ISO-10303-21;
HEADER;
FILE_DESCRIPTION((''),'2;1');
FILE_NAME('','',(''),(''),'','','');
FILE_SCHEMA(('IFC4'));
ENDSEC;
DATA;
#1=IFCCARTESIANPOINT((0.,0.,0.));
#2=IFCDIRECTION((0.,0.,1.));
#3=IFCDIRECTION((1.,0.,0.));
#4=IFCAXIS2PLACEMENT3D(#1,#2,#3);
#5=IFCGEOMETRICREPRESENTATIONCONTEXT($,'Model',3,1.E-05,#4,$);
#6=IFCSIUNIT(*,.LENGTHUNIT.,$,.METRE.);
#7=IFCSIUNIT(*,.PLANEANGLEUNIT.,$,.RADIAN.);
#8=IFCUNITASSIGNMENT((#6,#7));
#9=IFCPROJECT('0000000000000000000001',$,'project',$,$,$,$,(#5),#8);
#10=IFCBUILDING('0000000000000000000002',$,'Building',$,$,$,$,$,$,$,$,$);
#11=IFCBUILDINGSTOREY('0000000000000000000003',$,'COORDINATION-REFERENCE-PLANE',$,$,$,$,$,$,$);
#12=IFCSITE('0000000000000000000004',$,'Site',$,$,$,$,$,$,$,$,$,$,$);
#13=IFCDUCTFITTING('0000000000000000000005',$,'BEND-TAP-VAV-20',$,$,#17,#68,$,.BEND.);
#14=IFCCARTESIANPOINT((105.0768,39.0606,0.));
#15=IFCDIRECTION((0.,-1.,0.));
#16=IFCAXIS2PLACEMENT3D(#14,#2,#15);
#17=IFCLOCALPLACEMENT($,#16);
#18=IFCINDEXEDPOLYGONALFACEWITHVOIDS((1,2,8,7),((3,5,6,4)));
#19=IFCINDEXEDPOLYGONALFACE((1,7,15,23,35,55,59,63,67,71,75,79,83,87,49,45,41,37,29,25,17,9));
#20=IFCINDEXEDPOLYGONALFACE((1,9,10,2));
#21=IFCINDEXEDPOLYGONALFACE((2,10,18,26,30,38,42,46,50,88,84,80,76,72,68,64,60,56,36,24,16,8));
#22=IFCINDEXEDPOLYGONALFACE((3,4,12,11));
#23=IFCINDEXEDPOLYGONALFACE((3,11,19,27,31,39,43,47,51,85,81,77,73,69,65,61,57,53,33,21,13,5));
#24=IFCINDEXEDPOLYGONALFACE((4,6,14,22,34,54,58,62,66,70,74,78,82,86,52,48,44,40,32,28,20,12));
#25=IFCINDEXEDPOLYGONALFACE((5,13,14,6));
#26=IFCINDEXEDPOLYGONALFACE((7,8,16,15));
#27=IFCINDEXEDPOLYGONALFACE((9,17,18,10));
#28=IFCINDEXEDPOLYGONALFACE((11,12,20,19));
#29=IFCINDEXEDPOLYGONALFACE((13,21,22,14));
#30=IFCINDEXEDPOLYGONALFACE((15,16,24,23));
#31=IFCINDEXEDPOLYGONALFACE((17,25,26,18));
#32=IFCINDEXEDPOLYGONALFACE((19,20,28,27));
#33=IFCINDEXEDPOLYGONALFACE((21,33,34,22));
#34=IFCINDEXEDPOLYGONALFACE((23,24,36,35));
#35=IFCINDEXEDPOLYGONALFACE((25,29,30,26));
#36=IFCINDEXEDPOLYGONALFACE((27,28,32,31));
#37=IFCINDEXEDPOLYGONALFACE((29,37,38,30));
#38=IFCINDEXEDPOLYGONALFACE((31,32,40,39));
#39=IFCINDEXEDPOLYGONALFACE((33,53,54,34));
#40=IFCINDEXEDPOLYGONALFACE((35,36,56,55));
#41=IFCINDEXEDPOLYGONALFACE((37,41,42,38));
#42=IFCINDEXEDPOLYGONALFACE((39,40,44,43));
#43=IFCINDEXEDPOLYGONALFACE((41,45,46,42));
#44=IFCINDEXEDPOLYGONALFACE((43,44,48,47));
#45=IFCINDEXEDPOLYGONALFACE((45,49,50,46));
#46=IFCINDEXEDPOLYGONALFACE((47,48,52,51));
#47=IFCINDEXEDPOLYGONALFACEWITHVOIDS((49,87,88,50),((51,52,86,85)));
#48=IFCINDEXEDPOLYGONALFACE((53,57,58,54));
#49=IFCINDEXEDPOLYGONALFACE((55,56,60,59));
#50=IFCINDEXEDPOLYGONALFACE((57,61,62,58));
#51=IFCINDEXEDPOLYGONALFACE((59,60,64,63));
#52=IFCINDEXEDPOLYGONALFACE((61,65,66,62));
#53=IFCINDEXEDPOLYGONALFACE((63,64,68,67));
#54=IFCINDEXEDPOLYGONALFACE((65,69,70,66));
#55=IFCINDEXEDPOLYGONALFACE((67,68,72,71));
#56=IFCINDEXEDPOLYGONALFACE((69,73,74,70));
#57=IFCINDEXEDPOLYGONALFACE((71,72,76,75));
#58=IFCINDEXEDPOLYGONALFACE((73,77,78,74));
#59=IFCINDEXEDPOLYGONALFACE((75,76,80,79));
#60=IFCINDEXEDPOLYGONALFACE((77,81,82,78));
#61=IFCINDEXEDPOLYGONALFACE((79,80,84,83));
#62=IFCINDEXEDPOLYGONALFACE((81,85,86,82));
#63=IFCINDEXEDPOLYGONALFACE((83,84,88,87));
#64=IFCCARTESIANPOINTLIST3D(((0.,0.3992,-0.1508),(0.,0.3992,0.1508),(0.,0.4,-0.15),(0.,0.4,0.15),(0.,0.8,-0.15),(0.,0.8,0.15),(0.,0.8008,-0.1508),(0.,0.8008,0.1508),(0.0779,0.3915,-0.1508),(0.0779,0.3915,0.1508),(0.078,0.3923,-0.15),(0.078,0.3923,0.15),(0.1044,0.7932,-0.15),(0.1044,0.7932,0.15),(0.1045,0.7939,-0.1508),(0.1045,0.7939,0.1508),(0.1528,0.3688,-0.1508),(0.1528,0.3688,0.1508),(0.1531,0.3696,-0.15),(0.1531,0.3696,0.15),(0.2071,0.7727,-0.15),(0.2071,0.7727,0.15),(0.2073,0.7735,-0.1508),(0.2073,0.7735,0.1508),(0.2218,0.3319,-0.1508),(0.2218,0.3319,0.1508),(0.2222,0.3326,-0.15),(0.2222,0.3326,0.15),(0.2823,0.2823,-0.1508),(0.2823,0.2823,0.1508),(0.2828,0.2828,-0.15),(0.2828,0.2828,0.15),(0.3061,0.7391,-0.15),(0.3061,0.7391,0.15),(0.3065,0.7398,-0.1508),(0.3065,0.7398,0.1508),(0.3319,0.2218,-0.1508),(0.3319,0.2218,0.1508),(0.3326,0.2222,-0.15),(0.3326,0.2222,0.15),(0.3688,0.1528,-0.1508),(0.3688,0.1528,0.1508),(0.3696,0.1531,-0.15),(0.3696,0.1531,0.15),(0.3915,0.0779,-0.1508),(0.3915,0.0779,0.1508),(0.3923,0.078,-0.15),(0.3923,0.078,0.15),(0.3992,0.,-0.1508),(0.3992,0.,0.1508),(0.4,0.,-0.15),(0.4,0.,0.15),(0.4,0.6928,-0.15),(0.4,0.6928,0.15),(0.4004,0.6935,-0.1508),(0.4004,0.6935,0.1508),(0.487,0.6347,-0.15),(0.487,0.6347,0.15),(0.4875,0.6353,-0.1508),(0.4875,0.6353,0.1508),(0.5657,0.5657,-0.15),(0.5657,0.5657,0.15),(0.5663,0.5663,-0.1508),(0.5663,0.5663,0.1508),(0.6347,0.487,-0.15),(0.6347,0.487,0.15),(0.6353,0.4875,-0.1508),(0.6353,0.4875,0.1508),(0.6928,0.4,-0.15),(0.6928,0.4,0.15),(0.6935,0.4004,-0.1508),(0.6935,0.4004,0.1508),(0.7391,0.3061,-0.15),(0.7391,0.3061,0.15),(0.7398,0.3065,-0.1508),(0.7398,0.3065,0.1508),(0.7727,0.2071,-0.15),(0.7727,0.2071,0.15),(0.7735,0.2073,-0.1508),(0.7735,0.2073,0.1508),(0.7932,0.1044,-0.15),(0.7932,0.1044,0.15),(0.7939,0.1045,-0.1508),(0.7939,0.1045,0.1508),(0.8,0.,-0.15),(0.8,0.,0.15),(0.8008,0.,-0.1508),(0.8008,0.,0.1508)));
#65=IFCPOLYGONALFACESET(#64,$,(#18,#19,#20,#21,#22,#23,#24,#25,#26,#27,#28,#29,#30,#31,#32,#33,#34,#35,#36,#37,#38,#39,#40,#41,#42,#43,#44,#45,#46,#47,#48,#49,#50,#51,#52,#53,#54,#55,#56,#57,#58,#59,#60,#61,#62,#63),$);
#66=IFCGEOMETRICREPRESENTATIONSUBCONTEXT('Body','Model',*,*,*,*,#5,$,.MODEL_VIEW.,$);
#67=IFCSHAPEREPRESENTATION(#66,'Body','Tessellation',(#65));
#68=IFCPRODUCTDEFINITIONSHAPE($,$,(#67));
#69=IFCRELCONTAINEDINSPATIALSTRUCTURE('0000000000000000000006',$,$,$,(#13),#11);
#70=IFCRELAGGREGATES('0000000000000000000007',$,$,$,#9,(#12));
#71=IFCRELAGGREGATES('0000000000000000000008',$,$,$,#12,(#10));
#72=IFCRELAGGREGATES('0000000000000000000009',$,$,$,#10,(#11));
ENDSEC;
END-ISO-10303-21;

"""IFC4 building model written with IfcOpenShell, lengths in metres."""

from ifc_helpers import new_model, entity, si_unit, frame, origin_with_axes, place, context, subcontext, project, spatial, element, save


model = new_model("IFC4")

# Units and contexts
model_context = context("Model", 3, precision=1e-05, world=origin_with_axes())
body_context_1 = subcontext(model_context, "Body", "Model", "MODEL_VIEW")
ifc_project = project(units=[si_unit("LENGTHUNIT", "METRE"), si_unit("PLANEANGLEUNIT", "RADIAN")], contexts=[model_context])

# Site, building, storey
site = spatial("IfcSite", under=ifc_project, Name="Site")
building = spatial("IfcBuilding", under=site, Name="Building")
storey = spatial("IfcBuildingStorey", under=building, Name="COORDINATION-REFERENCE-PLANE")

# Duct fitting
duct_fitting_1_placement = place(None, frame((105.0768, 39.0606, 0.0), z_axis=(0.0, 0.0, 1.0), x_axis=(0.0, -1.0, 0.0)))
cartesian_point = entity("IfcCartesianPoint", [0.0, 0.0, 0.0])
element("IfcDuctFitting", 1, at=duct_fitting_1_placement, inside=storey, Name="BEND-TAP-VAV-20", PredefinedType="BEND", context=body_context_1, shape_type="SweptSolid", body=[
    entity("IfcRevolvedAreaSolid", entity("IfcRectangleHollowProfileDef", "AREA", None, entity("IfcAxis2Placement2D", entity("IfcCartesianPoint", [0.6, 0.0])), 0.4016, 0.3016, 0.0008), entity("IfcAxis2Placement3D", cartesian_point, entity("IfcDirection", [0.0, -1.0, 0.0]), entity("IfcDirection", [1.0, 0.0, 0.0])), entity("IfcAxis1Placement", cartesian_point, entity("IfcDirection", [0.0, 1.0, 0.0])), 1.570796),
])

save(model, "model.ifc")
